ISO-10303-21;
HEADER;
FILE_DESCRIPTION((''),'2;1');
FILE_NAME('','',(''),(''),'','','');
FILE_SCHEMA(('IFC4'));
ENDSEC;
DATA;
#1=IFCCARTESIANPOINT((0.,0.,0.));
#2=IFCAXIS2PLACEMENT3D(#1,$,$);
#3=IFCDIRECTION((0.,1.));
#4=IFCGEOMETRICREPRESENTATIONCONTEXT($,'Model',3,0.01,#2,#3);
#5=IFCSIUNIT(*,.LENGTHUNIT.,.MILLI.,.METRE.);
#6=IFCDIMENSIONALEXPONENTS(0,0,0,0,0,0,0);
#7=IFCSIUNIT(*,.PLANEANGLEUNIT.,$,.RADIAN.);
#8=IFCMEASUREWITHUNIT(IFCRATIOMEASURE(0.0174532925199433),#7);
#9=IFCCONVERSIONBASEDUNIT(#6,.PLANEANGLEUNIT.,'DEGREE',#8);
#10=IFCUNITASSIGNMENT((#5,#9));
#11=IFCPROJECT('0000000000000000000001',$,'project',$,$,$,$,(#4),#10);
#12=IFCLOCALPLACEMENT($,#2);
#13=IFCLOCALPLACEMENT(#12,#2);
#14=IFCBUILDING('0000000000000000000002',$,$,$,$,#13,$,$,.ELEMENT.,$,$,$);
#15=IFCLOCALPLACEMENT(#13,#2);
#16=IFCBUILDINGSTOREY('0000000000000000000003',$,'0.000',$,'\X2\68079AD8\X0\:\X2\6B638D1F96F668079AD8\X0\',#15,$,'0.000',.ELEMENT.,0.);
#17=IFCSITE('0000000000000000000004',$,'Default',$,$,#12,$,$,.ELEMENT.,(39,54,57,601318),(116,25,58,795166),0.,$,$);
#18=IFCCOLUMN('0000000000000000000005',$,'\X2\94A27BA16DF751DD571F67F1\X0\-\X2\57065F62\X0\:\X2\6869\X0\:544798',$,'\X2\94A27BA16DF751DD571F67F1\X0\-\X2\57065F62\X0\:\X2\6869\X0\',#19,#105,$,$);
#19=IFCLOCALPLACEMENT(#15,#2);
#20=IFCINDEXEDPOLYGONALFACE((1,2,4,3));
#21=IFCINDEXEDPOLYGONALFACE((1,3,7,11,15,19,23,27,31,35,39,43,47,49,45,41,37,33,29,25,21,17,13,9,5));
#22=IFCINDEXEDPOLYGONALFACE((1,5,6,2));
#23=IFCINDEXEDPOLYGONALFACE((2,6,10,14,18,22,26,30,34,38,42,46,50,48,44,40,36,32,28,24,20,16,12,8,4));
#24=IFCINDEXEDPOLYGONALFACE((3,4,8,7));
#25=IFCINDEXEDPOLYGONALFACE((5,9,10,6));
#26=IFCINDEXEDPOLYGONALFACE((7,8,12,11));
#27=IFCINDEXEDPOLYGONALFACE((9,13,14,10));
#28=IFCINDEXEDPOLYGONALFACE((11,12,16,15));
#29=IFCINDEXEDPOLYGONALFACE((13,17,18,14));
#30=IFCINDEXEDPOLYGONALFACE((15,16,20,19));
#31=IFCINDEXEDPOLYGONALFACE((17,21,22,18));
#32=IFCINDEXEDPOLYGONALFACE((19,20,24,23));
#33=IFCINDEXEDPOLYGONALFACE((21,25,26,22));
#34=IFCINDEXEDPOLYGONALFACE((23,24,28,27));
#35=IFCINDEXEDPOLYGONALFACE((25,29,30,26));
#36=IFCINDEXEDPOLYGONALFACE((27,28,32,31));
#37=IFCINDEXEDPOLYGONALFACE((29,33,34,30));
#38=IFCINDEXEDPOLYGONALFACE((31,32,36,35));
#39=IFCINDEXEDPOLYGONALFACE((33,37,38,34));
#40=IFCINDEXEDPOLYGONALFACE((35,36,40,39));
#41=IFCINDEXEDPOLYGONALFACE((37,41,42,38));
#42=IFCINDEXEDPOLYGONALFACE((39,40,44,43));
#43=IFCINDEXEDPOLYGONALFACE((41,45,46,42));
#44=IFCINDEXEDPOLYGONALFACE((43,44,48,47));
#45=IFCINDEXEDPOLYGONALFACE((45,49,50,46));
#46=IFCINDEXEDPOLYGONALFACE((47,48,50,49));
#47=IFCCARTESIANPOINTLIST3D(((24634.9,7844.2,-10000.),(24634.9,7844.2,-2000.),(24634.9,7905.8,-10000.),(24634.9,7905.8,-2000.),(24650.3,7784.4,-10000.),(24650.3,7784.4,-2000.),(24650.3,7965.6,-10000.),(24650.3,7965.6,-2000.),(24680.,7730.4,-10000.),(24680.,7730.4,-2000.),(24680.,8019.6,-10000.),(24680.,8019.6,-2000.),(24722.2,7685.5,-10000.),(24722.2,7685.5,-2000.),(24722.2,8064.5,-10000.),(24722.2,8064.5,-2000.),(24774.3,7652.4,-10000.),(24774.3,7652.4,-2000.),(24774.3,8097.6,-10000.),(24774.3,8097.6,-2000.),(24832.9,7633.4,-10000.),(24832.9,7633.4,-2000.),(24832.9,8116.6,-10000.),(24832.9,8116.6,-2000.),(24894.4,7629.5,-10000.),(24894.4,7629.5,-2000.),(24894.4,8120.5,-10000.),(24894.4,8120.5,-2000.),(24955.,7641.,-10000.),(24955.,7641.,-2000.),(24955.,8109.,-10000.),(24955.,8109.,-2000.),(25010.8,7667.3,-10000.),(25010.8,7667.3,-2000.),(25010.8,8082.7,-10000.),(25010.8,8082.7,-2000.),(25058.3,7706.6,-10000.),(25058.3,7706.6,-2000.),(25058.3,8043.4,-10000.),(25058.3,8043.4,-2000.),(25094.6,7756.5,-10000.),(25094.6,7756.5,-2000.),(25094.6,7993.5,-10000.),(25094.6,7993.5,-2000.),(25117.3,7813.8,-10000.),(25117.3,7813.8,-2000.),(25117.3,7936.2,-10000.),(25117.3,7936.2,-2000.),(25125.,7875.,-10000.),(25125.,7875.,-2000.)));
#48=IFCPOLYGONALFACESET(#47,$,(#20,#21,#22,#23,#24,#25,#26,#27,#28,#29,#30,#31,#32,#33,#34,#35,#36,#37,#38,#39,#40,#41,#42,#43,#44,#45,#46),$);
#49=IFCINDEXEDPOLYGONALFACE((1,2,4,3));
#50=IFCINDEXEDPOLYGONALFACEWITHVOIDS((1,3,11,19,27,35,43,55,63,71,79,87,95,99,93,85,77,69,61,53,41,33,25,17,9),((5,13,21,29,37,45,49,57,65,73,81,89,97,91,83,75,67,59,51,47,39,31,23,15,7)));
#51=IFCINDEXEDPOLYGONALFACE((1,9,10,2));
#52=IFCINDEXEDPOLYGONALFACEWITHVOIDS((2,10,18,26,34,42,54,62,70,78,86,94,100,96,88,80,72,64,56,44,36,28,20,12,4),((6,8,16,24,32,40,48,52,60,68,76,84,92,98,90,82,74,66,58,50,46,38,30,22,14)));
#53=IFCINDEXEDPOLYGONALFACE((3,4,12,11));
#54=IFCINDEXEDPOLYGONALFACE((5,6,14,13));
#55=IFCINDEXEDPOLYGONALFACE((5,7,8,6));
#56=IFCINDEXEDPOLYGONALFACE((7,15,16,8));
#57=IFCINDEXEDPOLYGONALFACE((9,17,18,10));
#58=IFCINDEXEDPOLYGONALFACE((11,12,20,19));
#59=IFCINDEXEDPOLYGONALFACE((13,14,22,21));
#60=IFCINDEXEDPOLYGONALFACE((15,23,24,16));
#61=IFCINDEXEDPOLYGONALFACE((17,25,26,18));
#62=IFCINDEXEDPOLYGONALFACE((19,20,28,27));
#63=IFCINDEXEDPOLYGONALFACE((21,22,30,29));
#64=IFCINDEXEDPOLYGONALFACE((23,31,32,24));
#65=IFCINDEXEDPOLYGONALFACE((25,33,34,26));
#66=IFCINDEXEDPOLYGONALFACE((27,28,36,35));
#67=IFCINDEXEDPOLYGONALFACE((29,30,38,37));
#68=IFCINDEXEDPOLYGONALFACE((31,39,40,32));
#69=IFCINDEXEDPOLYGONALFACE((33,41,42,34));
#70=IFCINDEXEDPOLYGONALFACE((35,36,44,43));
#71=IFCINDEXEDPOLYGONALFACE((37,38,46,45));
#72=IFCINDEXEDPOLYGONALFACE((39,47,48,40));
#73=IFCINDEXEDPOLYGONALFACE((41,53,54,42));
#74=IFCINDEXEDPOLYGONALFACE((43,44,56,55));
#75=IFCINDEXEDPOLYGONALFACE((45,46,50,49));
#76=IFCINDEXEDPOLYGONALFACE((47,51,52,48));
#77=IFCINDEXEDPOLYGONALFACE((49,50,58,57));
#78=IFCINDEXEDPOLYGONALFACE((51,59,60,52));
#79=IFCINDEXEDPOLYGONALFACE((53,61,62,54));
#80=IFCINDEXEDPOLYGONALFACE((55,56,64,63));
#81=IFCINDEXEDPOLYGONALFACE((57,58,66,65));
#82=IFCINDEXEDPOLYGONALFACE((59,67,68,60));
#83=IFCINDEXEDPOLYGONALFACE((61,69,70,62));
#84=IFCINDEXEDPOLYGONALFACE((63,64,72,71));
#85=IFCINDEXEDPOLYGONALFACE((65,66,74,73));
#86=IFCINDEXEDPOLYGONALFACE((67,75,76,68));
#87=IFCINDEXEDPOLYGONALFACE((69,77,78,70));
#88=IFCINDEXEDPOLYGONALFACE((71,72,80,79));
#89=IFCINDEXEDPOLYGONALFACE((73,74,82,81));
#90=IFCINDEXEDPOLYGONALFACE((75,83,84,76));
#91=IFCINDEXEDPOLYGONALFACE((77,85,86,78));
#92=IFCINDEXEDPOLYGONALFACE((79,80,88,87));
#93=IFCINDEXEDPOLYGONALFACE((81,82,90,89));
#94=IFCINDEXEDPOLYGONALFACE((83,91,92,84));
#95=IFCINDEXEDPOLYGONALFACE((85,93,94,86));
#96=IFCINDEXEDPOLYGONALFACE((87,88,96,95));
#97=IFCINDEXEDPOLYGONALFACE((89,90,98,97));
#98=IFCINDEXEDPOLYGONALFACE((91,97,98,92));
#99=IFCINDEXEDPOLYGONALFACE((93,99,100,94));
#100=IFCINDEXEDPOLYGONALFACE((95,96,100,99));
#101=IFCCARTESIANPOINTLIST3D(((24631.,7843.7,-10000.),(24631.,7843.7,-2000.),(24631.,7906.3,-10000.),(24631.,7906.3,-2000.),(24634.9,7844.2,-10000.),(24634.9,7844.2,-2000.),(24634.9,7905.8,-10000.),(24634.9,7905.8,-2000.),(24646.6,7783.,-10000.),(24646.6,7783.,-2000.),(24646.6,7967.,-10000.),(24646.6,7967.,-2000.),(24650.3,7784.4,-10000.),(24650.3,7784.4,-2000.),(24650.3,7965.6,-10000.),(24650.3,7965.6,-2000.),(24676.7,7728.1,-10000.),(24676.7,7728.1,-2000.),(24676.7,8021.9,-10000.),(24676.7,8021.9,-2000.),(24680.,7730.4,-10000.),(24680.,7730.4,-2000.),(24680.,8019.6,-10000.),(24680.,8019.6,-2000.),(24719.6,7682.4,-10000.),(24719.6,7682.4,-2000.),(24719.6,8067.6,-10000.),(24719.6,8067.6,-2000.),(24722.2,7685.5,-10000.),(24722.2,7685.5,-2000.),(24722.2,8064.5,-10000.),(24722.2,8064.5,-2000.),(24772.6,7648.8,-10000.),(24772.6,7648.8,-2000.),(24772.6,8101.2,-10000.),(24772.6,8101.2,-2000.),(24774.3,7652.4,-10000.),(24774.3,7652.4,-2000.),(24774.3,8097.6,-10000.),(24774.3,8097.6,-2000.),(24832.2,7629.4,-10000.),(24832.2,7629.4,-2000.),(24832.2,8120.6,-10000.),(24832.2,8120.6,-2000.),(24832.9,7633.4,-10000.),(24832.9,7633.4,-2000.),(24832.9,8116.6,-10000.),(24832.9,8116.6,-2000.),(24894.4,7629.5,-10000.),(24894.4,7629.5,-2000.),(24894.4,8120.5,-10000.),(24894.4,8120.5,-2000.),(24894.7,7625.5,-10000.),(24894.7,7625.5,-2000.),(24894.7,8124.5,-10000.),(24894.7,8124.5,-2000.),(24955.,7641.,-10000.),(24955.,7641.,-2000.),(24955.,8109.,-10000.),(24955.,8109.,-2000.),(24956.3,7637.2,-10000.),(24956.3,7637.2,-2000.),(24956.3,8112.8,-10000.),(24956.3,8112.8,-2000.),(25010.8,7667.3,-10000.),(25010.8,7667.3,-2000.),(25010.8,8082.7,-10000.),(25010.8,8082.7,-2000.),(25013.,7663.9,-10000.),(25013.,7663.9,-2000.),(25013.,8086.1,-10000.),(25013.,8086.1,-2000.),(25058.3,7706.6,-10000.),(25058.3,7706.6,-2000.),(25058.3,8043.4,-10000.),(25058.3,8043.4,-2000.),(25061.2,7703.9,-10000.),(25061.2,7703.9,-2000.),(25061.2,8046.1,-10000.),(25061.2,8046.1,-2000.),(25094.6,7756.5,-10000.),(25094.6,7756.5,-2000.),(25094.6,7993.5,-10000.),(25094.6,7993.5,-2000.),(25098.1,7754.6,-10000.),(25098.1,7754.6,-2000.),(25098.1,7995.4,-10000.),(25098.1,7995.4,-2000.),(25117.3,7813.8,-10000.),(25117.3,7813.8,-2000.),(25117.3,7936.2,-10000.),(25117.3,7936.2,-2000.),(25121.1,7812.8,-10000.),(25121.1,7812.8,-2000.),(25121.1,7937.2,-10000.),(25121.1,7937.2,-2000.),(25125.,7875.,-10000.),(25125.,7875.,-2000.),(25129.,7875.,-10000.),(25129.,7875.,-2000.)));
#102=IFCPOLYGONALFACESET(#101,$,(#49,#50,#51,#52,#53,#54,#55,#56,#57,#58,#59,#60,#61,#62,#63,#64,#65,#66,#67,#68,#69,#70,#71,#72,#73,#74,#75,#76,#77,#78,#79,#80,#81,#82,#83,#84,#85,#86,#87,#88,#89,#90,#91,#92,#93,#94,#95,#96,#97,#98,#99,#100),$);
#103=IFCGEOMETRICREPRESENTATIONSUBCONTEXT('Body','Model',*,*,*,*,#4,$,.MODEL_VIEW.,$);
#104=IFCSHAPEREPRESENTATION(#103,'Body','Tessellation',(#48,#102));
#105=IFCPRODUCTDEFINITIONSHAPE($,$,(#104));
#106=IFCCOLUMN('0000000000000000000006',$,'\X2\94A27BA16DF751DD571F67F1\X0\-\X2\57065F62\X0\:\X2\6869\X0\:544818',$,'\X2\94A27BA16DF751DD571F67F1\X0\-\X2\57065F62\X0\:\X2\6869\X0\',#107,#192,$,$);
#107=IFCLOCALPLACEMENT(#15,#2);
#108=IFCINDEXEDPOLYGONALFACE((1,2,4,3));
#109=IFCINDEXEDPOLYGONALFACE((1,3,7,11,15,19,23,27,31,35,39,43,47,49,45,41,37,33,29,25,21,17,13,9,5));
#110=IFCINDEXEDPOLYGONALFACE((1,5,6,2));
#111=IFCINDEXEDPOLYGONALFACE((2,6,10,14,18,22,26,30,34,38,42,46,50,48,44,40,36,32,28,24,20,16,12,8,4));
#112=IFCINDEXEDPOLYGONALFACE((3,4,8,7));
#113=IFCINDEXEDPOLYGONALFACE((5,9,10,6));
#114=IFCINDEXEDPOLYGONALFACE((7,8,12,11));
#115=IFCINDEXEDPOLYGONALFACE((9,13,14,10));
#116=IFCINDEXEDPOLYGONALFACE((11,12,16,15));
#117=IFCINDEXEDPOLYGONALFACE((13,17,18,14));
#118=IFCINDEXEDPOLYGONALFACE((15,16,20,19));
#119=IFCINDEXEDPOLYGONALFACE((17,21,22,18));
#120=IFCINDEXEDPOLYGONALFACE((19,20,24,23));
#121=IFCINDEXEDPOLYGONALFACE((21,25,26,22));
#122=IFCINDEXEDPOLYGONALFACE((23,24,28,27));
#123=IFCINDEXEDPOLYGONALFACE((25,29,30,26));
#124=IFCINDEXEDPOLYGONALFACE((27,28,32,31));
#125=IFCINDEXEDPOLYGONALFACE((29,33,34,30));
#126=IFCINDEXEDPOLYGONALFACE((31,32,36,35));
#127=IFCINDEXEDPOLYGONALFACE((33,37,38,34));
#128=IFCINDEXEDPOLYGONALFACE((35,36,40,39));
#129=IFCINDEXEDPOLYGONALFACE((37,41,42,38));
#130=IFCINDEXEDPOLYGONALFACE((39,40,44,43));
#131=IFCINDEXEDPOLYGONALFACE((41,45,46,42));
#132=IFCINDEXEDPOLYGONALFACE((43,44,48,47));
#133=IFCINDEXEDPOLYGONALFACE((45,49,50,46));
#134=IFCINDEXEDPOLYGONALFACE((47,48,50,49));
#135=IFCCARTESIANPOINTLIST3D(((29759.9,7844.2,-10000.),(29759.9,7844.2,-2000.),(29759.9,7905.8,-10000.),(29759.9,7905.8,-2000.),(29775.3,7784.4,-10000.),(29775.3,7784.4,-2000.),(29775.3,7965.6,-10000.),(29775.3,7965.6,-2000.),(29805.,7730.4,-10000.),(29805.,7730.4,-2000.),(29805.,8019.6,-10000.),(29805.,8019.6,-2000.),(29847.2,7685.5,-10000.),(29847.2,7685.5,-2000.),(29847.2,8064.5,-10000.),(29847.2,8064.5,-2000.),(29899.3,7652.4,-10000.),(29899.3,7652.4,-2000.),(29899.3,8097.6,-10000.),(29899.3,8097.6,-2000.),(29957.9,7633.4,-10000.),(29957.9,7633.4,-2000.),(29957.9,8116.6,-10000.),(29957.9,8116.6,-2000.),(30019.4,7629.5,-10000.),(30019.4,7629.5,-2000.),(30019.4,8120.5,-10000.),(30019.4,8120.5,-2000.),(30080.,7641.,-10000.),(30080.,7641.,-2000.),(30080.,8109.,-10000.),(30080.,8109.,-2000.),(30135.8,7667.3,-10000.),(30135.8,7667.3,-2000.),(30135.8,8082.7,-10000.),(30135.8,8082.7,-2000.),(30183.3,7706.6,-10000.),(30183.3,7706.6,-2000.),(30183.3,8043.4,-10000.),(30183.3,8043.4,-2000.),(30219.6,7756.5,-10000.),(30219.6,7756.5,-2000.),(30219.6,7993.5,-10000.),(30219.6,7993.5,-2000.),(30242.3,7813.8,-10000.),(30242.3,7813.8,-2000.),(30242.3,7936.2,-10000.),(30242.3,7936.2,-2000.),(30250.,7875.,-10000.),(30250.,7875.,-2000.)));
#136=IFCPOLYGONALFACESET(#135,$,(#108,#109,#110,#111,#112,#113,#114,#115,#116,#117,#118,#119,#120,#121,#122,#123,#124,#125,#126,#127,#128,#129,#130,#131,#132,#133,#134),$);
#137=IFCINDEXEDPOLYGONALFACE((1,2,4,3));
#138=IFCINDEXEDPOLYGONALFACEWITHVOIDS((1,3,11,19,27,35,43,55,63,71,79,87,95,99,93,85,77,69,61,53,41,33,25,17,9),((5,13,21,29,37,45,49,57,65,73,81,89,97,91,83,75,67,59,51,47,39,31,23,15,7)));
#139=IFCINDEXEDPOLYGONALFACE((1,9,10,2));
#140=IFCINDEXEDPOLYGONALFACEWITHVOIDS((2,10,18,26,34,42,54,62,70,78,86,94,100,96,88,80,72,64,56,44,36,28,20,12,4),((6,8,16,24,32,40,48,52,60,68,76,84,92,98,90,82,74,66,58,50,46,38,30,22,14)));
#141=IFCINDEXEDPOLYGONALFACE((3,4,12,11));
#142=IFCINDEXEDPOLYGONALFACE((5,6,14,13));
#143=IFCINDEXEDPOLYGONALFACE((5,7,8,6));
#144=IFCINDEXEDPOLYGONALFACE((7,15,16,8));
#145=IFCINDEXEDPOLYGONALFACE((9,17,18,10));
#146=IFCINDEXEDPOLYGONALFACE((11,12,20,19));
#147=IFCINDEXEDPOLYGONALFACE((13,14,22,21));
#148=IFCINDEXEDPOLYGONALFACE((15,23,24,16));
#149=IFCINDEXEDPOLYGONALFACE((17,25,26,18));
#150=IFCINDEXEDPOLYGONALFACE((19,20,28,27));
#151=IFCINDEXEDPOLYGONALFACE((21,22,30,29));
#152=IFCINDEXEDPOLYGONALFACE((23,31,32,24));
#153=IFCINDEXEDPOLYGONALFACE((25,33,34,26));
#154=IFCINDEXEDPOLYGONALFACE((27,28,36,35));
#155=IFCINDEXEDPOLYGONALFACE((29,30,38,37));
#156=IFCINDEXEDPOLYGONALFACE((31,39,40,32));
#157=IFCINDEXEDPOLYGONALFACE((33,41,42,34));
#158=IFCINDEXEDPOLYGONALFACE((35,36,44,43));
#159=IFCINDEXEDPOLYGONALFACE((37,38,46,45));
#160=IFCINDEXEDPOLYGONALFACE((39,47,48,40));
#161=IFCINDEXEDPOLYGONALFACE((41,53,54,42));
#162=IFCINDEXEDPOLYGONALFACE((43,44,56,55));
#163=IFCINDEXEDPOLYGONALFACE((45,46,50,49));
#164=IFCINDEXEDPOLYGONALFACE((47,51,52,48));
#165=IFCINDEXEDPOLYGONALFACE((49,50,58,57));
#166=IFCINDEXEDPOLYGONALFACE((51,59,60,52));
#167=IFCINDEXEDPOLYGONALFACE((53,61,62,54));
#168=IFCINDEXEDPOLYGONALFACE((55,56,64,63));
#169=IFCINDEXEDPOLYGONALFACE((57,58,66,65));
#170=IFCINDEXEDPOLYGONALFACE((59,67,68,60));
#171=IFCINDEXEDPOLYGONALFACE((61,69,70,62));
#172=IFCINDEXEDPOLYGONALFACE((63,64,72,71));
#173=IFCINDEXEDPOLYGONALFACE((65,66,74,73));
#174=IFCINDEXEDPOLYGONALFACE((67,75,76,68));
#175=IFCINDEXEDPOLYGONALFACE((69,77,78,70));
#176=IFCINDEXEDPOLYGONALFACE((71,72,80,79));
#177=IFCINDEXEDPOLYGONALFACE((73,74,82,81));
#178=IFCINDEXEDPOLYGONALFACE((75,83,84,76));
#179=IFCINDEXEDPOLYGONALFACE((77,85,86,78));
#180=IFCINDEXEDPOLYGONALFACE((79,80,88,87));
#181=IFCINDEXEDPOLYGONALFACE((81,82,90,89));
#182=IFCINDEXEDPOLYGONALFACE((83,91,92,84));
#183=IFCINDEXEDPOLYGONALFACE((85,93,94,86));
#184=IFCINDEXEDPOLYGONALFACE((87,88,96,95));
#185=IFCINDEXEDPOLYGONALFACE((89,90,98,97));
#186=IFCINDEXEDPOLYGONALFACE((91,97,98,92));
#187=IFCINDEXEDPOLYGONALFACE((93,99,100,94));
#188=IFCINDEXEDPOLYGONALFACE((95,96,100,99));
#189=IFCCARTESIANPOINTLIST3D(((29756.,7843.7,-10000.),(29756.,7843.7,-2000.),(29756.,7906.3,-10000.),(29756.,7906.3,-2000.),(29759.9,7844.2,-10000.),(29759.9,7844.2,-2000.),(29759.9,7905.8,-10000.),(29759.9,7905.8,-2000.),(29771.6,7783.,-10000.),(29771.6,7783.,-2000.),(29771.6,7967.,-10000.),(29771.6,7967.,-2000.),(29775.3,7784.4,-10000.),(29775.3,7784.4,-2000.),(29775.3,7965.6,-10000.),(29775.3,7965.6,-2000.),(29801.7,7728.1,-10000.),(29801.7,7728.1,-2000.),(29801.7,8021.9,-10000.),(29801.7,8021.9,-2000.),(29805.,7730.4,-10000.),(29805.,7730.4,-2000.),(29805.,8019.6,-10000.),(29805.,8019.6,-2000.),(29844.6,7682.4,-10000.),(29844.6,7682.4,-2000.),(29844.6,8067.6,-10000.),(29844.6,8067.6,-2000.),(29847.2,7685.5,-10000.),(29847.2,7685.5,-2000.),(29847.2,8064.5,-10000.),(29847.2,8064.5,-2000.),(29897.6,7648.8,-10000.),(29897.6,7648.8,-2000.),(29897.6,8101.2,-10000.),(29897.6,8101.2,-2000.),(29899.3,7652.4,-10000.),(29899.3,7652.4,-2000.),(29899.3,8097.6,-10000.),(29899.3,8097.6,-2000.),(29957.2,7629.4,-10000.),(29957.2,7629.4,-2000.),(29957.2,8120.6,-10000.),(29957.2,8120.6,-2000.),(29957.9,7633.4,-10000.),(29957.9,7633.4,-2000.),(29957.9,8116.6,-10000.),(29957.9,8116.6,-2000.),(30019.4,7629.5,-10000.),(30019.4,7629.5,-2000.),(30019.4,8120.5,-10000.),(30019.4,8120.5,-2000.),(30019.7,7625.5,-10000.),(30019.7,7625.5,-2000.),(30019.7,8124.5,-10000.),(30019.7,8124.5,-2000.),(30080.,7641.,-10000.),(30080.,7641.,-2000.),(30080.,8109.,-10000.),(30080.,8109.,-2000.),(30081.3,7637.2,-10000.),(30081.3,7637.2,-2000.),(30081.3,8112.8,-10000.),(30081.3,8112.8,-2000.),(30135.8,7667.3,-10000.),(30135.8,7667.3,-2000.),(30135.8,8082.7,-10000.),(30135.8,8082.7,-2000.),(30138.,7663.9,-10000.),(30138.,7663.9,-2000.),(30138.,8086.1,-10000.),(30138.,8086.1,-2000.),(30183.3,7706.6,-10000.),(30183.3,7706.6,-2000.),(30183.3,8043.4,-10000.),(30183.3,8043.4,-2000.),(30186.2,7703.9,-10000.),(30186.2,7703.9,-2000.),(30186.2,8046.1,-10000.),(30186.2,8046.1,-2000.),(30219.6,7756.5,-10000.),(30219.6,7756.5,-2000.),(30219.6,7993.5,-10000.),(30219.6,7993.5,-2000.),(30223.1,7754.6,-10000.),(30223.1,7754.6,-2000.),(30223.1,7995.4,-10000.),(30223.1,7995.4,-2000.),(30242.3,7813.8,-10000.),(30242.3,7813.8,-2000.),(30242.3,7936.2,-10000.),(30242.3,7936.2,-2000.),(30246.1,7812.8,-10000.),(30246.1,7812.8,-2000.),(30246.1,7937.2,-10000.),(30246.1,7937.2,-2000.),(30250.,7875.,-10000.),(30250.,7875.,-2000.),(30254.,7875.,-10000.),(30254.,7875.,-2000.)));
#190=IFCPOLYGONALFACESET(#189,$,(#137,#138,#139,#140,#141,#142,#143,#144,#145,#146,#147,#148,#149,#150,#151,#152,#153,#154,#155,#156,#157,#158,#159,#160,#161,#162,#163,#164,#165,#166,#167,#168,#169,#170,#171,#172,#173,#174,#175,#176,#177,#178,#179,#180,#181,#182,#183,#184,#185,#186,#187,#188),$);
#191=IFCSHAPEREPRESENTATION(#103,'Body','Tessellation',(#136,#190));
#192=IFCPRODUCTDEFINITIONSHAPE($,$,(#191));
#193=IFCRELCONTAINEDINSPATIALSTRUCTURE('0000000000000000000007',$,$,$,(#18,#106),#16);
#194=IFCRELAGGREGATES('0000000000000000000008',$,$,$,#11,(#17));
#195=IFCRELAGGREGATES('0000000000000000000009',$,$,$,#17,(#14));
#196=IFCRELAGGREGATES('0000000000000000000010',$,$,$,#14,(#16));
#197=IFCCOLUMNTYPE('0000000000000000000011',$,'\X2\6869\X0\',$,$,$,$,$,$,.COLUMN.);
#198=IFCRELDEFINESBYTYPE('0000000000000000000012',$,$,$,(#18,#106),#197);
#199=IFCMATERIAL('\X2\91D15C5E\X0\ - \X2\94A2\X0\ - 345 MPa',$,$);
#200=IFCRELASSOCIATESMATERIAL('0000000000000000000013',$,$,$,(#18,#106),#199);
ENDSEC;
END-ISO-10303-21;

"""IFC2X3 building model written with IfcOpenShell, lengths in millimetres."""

from ifc_helpers import new_model, entity, si_unit, converted_unit, direction, frame, frame_2d, origin, place, context, subcontext, project, spatial, circle, hollow_circle, extrude, source, transform, mapped, material, type_object, type_shapes, element, save


model = new_model("IFC2X3")

# Units and contexts
model_context = context("Model", 3, precision=0.01, world=origin(), true_north=direction((0.0, 1.0)))
body_context = subcontext(model_context, "Body", "Model", "MODEL_VIEW")
ifc_project = project(units=[si_unit("LENGTHUNIT", "METRE", prefix="MILLI"), converted_unit("PLANEANGLEUNIT", "DEGREE", entity("IfcRatioMeasure", 0.0174532925199433), si_unit("PLANEANGLEUNIT", "RADIAN"), dimensions=[0, 0, 0, 0, 0, 0, 0])], contexts=[model_context])

# Site, building, storey
site_placement = place(None, origin())
site = spatial("IfcSite", under=ifc_project, at=site_placement, Name="Default", CompositionType="ELEMENT", RefLatitude=(39, 54, 57, 601318), RefLongitude=(116, 25, 58, 795166), RefElevation=0.0)
building_placement = place(site_placement, origin())
building = spatial("IfcBuilding", under=site, at=building_placement, CompositionType="ELEMENT")
storey_placement = place(building_placement, origin())
storey = spatial("IfcBuildingStorey", under=building, at=storey_placement, Name="0.000", ObjectType="标高:正负零标高", LongName="0.000", CompositionType="ELEMENT", Elevation=0.0)

# Columns
ifc_material_1 = material(Name="金属 - 钢 - 345 MPa")
column_type = type_object("IfcColumnType", Name="桩", PredefinedType="COLUMN")
shared_shape = source(origin(), body_context, "Body", "SweptSolid", [
    extrude(circle(Radius=246.0, at=frame_2d((0.0, 0.0), x_axis=(1.0, 0.0))), frame((0.0, 0.0, -10000.0)), (0.0, 0.0, 1.0), 8000.0),
    extrude(hollow_circle(Radius=250.0, WallThickness=4.0, at=frame_2d((0.0, 0.0), x_axis=(1.0, 0.0))), frame((0.0, 0.0, -10000.0)), (0.0, 0.0, 1.0), 8000.0),
])
type_shapes(column_type, [shared_shape])
for number, where, name in (
    (1, (24879.0, 7875.0, 0.0), "钢管混凝土柱-圆形:桩:544798"),
    (2, (30004.0, 7875.0, 0.0), "钢管混凝土柱-圆形:桩:544818"),
):
    element("IfcColumn", number, at=place(storey_placement, frame(where)), inside=storey, type_object=column_type, material=ifc_material_1, Name=name, ObjectType="钢管混凝土柱-圆形:桩", context=body_context, shape_type="MappedRepresentation", body=[
        mapped(shared_shape, transform((0.0, 0.0, 0.0), scale=1.0)),
    ])

save(model, "model.ifc")
